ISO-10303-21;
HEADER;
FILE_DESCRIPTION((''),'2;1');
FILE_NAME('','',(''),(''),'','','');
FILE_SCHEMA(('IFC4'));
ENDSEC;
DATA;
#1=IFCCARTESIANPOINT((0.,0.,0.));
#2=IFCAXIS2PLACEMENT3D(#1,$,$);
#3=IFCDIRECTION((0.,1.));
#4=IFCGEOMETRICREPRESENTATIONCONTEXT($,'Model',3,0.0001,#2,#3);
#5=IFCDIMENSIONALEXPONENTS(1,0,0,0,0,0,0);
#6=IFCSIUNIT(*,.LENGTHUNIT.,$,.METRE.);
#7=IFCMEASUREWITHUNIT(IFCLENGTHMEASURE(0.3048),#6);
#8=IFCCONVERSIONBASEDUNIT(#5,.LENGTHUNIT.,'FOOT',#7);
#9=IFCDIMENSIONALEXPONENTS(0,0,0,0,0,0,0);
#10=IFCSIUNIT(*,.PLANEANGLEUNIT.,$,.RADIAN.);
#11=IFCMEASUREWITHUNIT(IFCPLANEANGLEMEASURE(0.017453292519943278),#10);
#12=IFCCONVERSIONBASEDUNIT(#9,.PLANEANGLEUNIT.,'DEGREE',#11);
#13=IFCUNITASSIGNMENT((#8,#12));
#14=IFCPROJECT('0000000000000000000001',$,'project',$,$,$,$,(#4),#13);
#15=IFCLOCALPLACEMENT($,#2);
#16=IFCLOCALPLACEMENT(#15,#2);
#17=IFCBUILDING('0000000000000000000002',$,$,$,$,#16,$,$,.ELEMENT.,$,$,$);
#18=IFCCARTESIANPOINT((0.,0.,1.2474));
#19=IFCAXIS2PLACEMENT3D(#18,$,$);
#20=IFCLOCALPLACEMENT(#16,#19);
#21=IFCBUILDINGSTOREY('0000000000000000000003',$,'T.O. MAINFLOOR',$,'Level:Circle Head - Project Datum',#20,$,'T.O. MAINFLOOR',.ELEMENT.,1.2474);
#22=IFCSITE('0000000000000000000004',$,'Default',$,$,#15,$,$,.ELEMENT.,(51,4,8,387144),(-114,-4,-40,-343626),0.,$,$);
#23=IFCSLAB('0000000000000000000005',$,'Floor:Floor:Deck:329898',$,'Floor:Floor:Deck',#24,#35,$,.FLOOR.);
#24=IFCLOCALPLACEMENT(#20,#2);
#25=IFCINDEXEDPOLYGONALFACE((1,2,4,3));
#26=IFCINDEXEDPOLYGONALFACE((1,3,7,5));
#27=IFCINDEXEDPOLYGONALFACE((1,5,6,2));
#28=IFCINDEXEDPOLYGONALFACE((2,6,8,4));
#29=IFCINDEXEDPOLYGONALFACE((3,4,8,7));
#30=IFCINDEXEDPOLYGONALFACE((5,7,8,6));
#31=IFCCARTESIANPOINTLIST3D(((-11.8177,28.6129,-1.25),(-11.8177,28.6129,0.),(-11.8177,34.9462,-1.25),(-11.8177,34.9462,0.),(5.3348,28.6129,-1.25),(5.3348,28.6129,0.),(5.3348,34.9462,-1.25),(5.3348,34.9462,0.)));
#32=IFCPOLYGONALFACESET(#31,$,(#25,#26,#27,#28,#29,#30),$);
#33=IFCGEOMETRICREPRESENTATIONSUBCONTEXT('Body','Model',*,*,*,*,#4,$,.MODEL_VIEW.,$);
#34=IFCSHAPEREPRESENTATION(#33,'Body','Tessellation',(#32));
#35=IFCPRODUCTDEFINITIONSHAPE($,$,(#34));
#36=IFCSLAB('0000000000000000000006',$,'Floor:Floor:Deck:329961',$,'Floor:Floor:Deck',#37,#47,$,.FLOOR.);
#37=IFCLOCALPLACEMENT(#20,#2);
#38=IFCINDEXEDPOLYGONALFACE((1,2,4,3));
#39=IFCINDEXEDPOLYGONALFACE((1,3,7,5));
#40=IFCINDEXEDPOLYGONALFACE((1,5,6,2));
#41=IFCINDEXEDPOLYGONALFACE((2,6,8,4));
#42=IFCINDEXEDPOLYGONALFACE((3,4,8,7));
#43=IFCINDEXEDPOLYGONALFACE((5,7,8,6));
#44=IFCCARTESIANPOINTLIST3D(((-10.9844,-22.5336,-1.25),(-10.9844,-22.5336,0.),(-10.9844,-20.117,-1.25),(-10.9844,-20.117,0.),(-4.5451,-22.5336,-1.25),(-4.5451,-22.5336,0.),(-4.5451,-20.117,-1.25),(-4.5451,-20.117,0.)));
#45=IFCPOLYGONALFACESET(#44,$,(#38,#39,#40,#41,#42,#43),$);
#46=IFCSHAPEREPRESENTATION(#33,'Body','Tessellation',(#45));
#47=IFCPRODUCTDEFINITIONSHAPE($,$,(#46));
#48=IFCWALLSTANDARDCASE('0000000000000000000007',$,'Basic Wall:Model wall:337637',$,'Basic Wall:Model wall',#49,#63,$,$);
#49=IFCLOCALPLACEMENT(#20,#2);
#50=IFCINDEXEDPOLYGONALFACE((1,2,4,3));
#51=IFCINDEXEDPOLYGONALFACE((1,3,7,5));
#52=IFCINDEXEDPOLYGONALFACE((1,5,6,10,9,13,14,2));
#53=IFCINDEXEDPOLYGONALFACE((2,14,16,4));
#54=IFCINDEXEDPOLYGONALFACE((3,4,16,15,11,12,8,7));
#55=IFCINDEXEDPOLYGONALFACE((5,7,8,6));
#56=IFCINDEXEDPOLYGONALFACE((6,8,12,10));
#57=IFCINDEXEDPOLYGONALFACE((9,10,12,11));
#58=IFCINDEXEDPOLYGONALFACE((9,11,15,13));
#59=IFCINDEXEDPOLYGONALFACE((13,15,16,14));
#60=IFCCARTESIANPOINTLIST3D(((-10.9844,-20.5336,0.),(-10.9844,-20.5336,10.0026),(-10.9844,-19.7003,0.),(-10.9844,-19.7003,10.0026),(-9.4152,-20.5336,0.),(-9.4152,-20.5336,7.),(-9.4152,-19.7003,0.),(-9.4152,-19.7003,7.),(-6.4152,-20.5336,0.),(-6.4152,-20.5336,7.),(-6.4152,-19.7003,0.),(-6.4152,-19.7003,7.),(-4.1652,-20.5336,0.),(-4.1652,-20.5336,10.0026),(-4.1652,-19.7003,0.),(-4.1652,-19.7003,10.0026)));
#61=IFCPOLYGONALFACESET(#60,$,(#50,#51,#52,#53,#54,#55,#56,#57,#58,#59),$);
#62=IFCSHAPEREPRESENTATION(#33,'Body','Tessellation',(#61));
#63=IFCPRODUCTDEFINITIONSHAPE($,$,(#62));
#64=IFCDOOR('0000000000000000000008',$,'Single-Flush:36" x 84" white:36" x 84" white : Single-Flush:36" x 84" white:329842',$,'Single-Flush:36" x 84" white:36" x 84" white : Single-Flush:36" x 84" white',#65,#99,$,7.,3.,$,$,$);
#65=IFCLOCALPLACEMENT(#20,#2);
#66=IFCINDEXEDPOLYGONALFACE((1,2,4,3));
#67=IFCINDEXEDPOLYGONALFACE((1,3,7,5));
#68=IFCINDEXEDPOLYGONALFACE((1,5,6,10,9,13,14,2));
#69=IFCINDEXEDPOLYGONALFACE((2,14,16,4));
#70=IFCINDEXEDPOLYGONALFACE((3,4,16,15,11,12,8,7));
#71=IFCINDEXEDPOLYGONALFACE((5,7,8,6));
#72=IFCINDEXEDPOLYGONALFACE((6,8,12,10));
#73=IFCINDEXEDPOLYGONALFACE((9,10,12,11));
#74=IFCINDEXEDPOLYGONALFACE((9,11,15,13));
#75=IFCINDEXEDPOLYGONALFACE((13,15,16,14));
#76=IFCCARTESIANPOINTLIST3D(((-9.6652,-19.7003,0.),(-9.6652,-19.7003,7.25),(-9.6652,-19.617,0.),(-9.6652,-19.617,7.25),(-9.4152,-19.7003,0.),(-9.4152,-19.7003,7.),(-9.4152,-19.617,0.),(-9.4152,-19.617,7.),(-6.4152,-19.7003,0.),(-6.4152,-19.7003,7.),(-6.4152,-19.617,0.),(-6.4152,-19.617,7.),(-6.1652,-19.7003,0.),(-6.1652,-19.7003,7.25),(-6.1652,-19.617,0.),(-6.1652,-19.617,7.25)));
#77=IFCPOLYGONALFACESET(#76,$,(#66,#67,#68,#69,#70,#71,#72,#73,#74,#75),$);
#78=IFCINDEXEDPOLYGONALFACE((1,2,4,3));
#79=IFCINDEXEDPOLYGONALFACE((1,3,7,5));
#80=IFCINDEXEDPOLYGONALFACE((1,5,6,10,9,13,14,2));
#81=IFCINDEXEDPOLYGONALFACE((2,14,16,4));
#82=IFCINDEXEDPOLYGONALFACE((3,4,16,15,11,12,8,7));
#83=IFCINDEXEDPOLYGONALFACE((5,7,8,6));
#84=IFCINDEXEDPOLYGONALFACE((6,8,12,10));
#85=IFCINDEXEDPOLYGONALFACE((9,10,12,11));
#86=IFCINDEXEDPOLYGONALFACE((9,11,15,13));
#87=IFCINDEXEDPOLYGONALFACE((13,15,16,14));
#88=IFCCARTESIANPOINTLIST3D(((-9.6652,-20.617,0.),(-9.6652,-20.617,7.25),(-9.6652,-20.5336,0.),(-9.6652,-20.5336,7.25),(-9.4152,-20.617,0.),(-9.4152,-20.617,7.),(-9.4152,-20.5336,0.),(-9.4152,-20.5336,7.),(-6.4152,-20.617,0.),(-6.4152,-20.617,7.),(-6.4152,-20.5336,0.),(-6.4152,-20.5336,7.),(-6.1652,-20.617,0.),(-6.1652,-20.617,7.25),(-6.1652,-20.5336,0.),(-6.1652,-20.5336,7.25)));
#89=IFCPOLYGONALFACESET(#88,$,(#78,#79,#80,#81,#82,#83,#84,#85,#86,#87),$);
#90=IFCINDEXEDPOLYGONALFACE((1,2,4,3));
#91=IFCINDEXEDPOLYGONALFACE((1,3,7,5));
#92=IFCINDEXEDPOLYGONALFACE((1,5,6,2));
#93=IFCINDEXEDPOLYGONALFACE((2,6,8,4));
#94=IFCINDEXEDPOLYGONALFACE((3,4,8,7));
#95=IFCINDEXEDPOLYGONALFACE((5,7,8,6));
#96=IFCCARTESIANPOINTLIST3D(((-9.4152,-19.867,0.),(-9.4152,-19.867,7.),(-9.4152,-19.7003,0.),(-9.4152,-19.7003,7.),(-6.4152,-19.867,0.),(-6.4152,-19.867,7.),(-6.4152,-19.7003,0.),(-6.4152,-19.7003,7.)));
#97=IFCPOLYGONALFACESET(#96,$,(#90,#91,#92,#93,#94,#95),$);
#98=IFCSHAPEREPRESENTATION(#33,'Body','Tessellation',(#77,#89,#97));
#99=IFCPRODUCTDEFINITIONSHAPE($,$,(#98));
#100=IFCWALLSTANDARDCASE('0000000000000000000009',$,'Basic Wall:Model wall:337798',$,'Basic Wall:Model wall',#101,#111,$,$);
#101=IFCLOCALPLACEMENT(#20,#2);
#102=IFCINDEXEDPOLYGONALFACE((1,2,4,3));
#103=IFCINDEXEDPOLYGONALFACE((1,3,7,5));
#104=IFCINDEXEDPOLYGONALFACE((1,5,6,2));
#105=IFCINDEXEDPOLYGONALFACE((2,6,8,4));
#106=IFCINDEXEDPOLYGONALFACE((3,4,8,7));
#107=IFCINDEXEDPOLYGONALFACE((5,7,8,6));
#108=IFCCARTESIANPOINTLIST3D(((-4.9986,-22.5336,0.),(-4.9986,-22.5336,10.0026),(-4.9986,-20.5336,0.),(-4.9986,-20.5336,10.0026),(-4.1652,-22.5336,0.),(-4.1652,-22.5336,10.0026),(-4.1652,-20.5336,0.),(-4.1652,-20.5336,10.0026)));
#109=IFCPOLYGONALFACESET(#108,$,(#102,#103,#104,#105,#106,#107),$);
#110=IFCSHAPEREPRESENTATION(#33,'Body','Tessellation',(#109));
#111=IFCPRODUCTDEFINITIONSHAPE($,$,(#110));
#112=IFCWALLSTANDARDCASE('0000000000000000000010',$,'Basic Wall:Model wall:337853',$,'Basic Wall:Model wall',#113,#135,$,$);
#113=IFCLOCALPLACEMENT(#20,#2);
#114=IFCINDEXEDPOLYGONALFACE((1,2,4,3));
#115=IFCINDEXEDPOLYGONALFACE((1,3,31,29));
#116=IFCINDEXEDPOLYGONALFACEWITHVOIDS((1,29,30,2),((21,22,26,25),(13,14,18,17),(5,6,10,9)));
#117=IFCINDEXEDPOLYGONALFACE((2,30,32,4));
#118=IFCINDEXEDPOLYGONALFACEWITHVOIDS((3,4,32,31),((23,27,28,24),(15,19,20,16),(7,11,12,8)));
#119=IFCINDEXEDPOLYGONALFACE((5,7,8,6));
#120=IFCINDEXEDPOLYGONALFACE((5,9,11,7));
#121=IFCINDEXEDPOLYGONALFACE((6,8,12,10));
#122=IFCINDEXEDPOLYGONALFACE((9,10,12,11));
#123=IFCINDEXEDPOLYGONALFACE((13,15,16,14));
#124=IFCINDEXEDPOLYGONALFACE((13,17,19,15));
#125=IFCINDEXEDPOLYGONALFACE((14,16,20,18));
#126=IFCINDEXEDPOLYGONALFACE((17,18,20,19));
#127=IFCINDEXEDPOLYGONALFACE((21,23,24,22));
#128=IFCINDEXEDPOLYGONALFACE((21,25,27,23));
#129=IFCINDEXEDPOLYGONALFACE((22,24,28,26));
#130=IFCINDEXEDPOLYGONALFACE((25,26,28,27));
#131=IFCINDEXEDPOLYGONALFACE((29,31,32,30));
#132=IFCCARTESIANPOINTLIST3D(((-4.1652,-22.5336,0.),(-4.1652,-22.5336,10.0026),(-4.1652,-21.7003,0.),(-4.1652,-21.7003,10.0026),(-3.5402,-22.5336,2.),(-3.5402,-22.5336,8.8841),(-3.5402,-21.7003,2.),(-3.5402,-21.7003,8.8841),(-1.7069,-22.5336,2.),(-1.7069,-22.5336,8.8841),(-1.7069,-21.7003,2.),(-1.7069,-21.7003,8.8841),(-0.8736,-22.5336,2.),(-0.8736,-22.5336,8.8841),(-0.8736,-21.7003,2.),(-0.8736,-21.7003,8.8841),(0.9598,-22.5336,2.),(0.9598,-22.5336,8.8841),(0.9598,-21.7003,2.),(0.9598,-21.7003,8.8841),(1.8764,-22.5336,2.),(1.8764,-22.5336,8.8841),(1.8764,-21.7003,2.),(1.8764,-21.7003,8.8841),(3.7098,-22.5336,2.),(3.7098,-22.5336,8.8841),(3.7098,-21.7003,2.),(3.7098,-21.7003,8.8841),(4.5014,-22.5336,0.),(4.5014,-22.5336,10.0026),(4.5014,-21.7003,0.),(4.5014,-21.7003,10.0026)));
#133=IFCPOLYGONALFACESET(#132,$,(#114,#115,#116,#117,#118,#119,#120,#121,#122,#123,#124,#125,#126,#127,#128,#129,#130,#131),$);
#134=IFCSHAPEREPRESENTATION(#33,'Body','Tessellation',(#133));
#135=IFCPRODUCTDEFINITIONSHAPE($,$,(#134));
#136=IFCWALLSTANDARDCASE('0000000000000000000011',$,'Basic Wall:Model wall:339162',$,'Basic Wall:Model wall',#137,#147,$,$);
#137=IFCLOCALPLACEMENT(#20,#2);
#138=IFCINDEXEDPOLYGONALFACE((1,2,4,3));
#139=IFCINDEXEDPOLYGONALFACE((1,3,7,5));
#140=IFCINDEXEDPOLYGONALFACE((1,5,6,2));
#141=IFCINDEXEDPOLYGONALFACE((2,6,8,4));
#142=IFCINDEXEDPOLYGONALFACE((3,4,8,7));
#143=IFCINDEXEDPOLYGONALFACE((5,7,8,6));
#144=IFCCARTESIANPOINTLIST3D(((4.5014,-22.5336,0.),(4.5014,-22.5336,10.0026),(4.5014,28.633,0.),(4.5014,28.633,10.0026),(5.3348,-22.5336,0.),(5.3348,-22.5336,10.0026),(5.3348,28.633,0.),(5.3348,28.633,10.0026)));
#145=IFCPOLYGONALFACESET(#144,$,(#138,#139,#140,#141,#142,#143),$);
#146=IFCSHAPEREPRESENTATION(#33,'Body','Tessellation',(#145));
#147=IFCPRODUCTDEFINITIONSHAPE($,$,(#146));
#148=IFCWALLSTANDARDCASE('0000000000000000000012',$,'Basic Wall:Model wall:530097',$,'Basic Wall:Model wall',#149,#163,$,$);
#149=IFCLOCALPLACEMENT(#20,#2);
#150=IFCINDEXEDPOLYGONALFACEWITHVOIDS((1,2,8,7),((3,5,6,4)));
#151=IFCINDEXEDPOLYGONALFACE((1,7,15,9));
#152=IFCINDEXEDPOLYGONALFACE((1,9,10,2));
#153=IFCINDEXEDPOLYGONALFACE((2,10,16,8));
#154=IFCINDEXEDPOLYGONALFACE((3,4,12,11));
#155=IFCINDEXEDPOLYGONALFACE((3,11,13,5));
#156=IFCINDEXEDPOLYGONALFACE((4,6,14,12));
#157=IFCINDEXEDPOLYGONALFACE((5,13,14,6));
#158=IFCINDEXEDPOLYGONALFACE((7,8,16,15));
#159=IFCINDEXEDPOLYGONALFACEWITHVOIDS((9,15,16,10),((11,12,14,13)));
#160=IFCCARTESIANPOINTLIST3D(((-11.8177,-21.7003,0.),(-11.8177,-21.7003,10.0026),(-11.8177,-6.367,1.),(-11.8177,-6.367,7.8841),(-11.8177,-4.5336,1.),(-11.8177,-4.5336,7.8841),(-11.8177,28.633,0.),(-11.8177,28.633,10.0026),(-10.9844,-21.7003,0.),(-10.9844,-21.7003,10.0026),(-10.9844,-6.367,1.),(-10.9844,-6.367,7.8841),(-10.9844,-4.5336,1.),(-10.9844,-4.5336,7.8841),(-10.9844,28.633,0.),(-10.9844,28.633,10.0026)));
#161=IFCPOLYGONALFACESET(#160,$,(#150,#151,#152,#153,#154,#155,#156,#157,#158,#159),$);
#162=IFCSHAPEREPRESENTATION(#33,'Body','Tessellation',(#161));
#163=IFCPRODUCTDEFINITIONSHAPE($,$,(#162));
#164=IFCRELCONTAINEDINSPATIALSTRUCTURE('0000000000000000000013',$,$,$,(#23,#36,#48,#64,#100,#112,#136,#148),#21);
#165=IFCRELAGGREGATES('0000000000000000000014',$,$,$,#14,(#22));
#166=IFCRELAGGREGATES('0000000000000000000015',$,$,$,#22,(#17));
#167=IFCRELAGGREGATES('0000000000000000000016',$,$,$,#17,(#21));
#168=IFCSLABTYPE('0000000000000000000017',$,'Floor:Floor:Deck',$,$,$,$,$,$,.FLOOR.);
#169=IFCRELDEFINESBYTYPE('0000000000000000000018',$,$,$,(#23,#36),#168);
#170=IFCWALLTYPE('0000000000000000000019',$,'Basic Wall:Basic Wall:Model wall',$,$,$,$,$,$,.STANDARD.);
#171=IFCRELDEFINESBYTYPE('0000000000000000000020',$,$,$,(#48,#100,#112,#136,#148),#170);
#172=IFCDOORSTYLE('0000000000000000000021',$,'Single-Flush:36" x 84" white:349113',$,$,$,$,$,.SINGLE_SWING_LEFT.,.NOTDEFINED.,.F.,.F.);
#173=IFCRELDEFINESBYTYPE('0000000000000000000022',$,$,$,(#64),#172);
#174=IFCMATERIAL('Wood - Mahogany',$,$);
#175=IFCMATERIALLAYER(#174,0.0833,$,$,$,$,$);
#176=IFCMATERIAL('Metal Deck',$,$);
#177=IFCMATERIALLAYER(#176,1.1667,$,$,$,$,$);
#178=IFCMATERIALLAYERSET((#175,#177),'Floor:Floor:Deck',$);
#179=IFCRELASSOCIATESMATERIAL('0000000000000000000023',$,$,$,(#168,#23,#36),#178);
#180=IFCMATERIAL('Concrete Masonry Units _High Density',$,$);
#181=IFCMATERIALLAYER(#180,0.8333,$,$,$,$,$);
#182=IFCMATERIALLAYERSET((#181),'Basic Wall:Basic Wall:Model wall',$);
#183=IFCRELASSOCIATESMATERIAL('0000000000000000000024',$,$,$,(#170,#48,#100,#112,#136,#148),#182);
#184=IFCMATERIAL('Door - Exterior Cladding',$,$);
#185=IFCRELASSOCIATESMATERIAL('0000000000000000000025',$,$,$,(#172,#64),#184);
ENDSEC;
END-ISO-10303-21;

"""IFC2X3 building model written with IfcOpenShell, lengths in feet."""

from ifc_helpers import new_model, entity, si_unit, converted_unit, direction, frame, frame_2d, origin, origin_2d_with_axis, place, context, subcontext, project, spatial, polyline, rectangle, outline, extrude, source, transform, mapped, material, layer, layer_set, layer_usage, type_object, type_shapes, element, fill, save


model = new_model("IFC2X3")

# Units and contexts
model_context = context("Model", 3, precision=0.0001, world=origin(), true_north=direction((0.0, 1.0)))
body_context = subcontext(model_context, "Body", "Model", "MODEL_VIEW")
ifc_project = project(units=[converted_unit("LENGTHUNIT", "FOOT", entity("IfcLengthMeasure", 0.3048), si_unit("LENGTHUNIT", "METRE"), dimensions=[1, 0, 0, 0, 0, 0, 0]), converted_unit("PLANEANGLEUNIT", "DEGREE", entity("IfcPlaneAngleMeasure", 0.017453292519943278), si_unit("PLANEANGLEUNIT", "RADIAN"), dimensions=[0, 0, 0, 0, 0, 0, 0])], contexts=[model_context])

# Site, building, storey
site_placement = place(None, origin())
site = spatial("IfcSite", under=ifc_project, at=site_placement, Name="Default", CompositionType="ELEMENT", RefLatitude=(51, 4, 8, 387144), RefLongitude=(-114, -4, -40, -343626), RefElevation=0.0)
building_placement = place(site_placement, origin())
building = spatial("IfcBuilding", under=site, at=building_placement, CompositionType="ELEMENT")
storey_placement = place(building_placement, frame((0.0, 0.0, 1.2474)))
storey = spatial("IfcBuildingStorey", under=building, at=storey_placement, Name="T.O. MAINFLOOR", ObjectType="Level:Circle Head - Project Datum", LongName="T.O. MAINFLOOR", CompositionType="ELEMENT", Elevation=1.2474)

# Slabs
ifc_material_1 = material(Name="Wood - Mahogany")
ifc_layer_1 = layer(ifc_material_1, 0.0833)
ifc_material_2 = material(Name="Metal Deck")
ifc_layer_2 = layer(ifc_material_2, 1.1667)
ifc_layer_set_1 = layer_set([ifc_layer_1, ifc_layer_2], Name="Floor:Floor:Deck")
ifc_layer_usage_1 = layer_usage(ifc_layer_set_1, "AXIS3", "POSITIVE", 0.0)
slab_type_1 = type_object("IfcSlabType", Name="Floor:Floor:Deck", PredefinedType="FLOOR", material=ifc_layer_set_1)
slab_1_placement = place(storey_placement, origin())
element("IfcSlab", 1, at=slab_1_placement, inside=storey, type_object=slab_type_1, material=ifc_layer_usage_1, Name="Floor:Floor:Deck:329898", ObjectType="Floor:Floor:Deck", PredefinedType="FLOOR", context=body_context, shape_type="SweptSolid", body=[
    extrude(rectangle(XDim=6.3333, YDim=17.1525, at=frame_2d((0.0, 0.0), x_axis=(1.0, 0.0))), frame((-3.2415, 31.7795, 0.0), z_axis=(0.0, 0.0, -1.0), x_axis=(0.0, 1.0, 0.0)), (0.0, 0.0, 1.0), 1.25),
])
ifc_layer_usage_2 = layer_usage(ifc_layer_set_1, "AXIS3", "POSITIVE", 0.0)
slab_2_placement = place(storey_placement, origin())
element("IfcSlab", 2, at=slab_2_placement, inside=storey, type_object=slab_type_1, material=ifc_layer_usage_2, Name="Floor:Floor:Deck:329961", ObjectType="Floor:Floor:Deck", PredefinedType="FLOOR", context=body_context, shape_type="SweptSolid", body=[
    extrude(rectangle(XDim=2.4167, YDim=6.4392, at=origin_2d_with_axis()), frame((-7.7648, -21.3253, 0.0), z_axis=(0.0, 0.0, -1.0), x_axis=(0.0, 1.0, 0.0)), (0.0, 0.0, 1.0), 1.25),
])

# Wall, opening, door
ifc_material_3 = material(Name="Concrete Masonry Units _High Density")
ifc_layer_3 = layer(ifc_material_3, 0.8333)
ifc_layer_set_2 = layer_set([ifc_layer_3], Name="Basic Wall:Basic Wall:Model wall")
ifc_layer_usage_3 = layer_usage(ifc_layer_set_2, "AXIS2", "NEGATIVE", 0.4167)
wall_type_1 = type_object("IfcWallType", Name="Basic Wall:Basic Wall:Model wall", PredefinedType="STANDARD", material=ifc_layer_set_2)
wall_1_placement = place(storey_placement, frame((-10.9844, -20.117, 0.0)))
wall_1 = element("IfcWallStandardCase", 3, at=wall_1_placement, inside=storey, type_object=wall_type_1, material=ifc_layer_usage_3, Name="Basic Wall:Model wall:337637", ObjectType="Basic Wall:Model wall", context=body_context, shape_type="SweptSolid", body=[
    extrude(rectangle(XDim=6.8192, YDim=0.8333, at=frame_2d((3.4096, 0.0), x_axis=(-1.0, 0.0))), origin(), (0.0, 0.0, 1.0), 10.0026),
])
opening_1_placement = place(wall_1_placement, frame((10.9844, 20.117, 0.0)))
opening_1 = element("IfcOpeningElement", 4, at=opening_1_placement, cuts=wall_1, ObjectType="Opening", context=body_context, shape_type="SweptSolid", body=[
    extrude(rectangle(XDim=7.0, YDim=3.0, at=frame_2d((0.0, 0.0), x_axis=(1.0, 0.0))), frame((-7.9152, -20.542, 3.5), z_axis=(0.0, 1.0, 0.0), x_axis=(0.0, 0.0, 1.0)), (0.0, 0.0, 1.0), 0.85),
])
ifc_material_4 = material(Name="Door - Exterior Cladding")
door_style_1 = type_object("IfcDoorStyle", Name="Single-Flush:36\" x 84\" white:349113", ConstructionType="NOTDEFINED", OperationType="SINGLE_SWING_LEFT", ParameterTakesPrecedence=False, Sizeable=False, material=ifc_material_4)
shared_shape_1 = source(origin(), body_context, "Body", "SweptSolid", [
    extrude(outline(polyline([(-1.75, -3.6875), (1.75, -3.6875), (1.75, 3.5625), (1.5, 3.5625), (1.5, -3.4375), (-1.5, -3.4375), (-1.5, 3.5625), (-1.75, 3.5625), (-1.75, -3.6875)])), frame((1.5, -0.0083, 3.5625), z_axis=(0.0, 1.0, 0.0), x_axis=(1.0, 0.0, 0.0)), (0.0, 0.0, 1.0), 0.0833),
    extrude(outline(polyline([(-3.5625, -1.75), (3.6875, -1.75), (3.6875, 1.75), (-3.5625, 1.75), (-3.5625, 1.5), (3.4375, 1.5), (3.4375, -1.5), (-3.5625, -1.5), (-3.5625, -1.75)])), frame((1.5, -0.925, 3.5625), z_axis=(0.0, 1.0, 0.0), x_axis=(0.0, 0.0, 1.0)), (0.0, 0.0, 1.0), 0.0833),
    extrude(rectangle(XDim=0.1667, YDim=3.0, at=origin_2d_with_axis()), frame((1.5, -0.0917, 0.0), z_axis=(0.0, 0.0, 1.0), x_axis=(0.0, 1.0, 0.0)), (0.0, 0.0, 1.0), 7.0),
])
type_shapes(door_style_1, [shared_shape_1])
door_1_placement = place(opening_1_placement, frame((-9.4152, -19.692, 0.0)))
door_1 = element("IfcDoor", 5, at=door_1_placement, inside=storey, type_object=door_style_1, material=ifc_material_4, Name="Single-Flush:36\" x 84\" white:36\" x 84\" white : Single-Flush:36\" x 84\" white:329842", ObjectType="Single-Flush:36\" x 84\" white:36\" x 84\" white : Single-Flush:36\" x 84\" white", OverallHeight=7.0, OverallWidth=3.0, context=body_context, shape_type="MappedRepresentation", body=[
    mapped(shared_shape_1, transform((0.0, 0.0, 0.0), scale=1.0)),
])
fill(opening_1, door_1)

# Wall
ifc_layer_usage_4 = layer_usage(ifc_layer_set_2, "AXIS2", "NEGATIVE", 0.4167)
wall_2_placement = place(storey_placement, frame((-4.5819, -20.5336, 0.0), z_axis=(0.0, 0.0, 1.0), x_axis=(0.0, -1.0, 0.0)))
element("IfcWallStandardCase", 6, at=wall_2_placement, inside=storey, type_object=wall_type_1, material=ifc_layer_usage_4, Name="Basic Wall:Model wall:337798", ObjectType="Basic Wall:Model wall", context=body_context, shape_type="SweptSolid", body=[
    extrude(rectangle(XDim=2.0, YDim=0.8333, at=frame_2d((1.0, 0.0), x_axis=(-1.0, 0.0))), origin(), (0.0, 0.0, 1.0), 10.0026),
])

# Wall, openings
ifc_layer_usage_5 = layer_usage(ifc_layer_set_2, "AXIS2", "NEGATIVE", 0.4167)
wall_3_placement = place(storey_placement, frame((-4.1652, -22.117, 0.0)))
wall_3 = element("IfcWallStandardCase", 7, at=wall_3_placement, inside=storey, type_object=wall_type_1, material=ifc_layer_usage_5, Name="Basic Wall:Model wall:337853", ObjectType="Basic Wall:Model wall", context=body_context, shape_type="SweptSolid", body=[
    extrude(rectangle(XDim=8.6667, YDim=0.8333, at=frame_2d((4.3333, 0.0), x_axis=(-1.0, 0.0))), origin(), (0.0, 0.0, 1.0), 10.0026),
])
opening_2_placement = place(wall_3_placement, frame((4.1652, 22.117, 0.0)))
element("IfcOpeningElement", 8, at=opening_2_placement, cuts=wall_3, ObjectType="Opening", context=body_context, shape_type="SweptSolid", body=[
    extrude(rectangle(XDim=6.8841, YDim=1.8333, at=frame_2d((0.0, 0.0), x_axis=(1.0, 0.0))), frame((2.7931, -22.542, 5.4421), z_axis=(0.0, 1.0, 0.0), x_axis=(0.0, 0.0, 1.0)), (0.0, 0.0, 1.0), 0.85),
])
opening_3_placement = place(wall_3_placement, frame((4.1652, 22.117, 0.0)))
element("IfcOpeningElement", 9, at=opening_3_placement, cuts=wall_3, ObjectType="Opening", context=body_context, shape_type="SweptSolid", body=[
    extrude(rectangle(XDim=6.8841, YDim=1.8333, at=frame_2d((0.0, 0.0), x_axis=(1.0, 0.0))), frame((0.0431, -22.542, 5.4421), z_axis=(0.0, 1.0, 0.0), x_axis=(0.0, 0.0, 1.0)), (0.0, 0.0, 1.0), 0.85),
])
opening_4_placement = place(wall_3_placement, frame((4.1652, 22.117, 0.0)))
element("IfcOpeningElement", 10, at=opening_4_placement, cuts=wall_3, ObjectType="Opening", context=body_context, shape_type="SweptSolid", body=[
    extrude(rectangle(XDim=6.8841, YDim=1.8333, at=frame_2d((0.0, 0.0), x_axis=(1.0, 0.0))), frame((-2.6236, -22.542, 5.4421), z_axis=(0.0, 1.0, 0.0), x_axis=(0.0, 0.0, 1.0)), (0.0, 0.0, 1.0), 0.85),
])

# Wall
ifc_layer_usage_6 = layer_usage(ifc_layer_set_2, "AXIS2", "NEGATIVE", 0.4167)
wall_4_placement = place(storey_placement, frame((4.9181, 28.633, 0.0), z_axis=(0.0, 0.0, 1.0), x_axis=(0.0, -1.0, 0.0)))
element("IfcWallStandardCase", 11, at=wall_4_placement, inside=storey, type_object=wall_type_1, material=ifc_layer_usage_6, Name="Basic Wall:Model wall:339162", ObjectType="Basic Wall:Model wall", context=body_context, shape_type="SweptSolid", body=[
    extrude(rectangle(XDim=51.1667, YDim=0.8333, at=frame_2d((25.5833, 0.0), x_axis=(-1.0, 0.0))), origin(), (0.0, 0.0, 1.0), 10.0026),
])

# Wall, opening
ifc_layer_usage_7 = layer_usage(ifc_layer_set_2, "AXIS2", "NEGATIVE", 0.4167)
wall_5_placement = place(storey_placement, frame((-11.401, 28.633, 0.0), z_axis=(0.0, 0.0, 1.0), x_axis=(0.0, -1.0, 0.0)))
wall_5 = element("IfcWallStandardCase", 12, at=wall_5_placement, inside=storey, type_object=wall_type_1, material=ifc_layer_usage_7, Name="Basic Wall:Model wall:530097", ObjectType="Basic Wall:Model wall", context=body_context, shape_type="SweptSolid", body=[
    extrude(rectangle(XDim=50.3333, YDim=0.8333, at=frame_2d((25.1667, 0.0), x_axis=(-1.0, 0.0))), origin(), (0.0, 0.0, 1.0), 10.0026),
])
opening_5_placement = place(wall_5_placement, frame((28.633, 11.401, 0.0), z_axis=(0.0, 0.0, 1.0), x_axis=(0.0, 1.0, 0.0)))
element("IfcOpeningElement", 13, at=opening_5_placement, cuts=wall_5, ObjectType="Opening", context=body_context, shape_type="SweptSolid", body=[
    extrude(rectangle(XDim=6.8841, YDim=1.8333, at=frame_2d((0.0, 0.0), x_axis=(1.0, 0.0))), frame((-11.826, -5.4503, 4.4421), z_axis=(1.0, 0.0, 0.0), x_axis=(0.0, 0.0, 1.0)), (0.0, 0.0, 1.0), 0.85),
])

save(model, "model.ifc")
